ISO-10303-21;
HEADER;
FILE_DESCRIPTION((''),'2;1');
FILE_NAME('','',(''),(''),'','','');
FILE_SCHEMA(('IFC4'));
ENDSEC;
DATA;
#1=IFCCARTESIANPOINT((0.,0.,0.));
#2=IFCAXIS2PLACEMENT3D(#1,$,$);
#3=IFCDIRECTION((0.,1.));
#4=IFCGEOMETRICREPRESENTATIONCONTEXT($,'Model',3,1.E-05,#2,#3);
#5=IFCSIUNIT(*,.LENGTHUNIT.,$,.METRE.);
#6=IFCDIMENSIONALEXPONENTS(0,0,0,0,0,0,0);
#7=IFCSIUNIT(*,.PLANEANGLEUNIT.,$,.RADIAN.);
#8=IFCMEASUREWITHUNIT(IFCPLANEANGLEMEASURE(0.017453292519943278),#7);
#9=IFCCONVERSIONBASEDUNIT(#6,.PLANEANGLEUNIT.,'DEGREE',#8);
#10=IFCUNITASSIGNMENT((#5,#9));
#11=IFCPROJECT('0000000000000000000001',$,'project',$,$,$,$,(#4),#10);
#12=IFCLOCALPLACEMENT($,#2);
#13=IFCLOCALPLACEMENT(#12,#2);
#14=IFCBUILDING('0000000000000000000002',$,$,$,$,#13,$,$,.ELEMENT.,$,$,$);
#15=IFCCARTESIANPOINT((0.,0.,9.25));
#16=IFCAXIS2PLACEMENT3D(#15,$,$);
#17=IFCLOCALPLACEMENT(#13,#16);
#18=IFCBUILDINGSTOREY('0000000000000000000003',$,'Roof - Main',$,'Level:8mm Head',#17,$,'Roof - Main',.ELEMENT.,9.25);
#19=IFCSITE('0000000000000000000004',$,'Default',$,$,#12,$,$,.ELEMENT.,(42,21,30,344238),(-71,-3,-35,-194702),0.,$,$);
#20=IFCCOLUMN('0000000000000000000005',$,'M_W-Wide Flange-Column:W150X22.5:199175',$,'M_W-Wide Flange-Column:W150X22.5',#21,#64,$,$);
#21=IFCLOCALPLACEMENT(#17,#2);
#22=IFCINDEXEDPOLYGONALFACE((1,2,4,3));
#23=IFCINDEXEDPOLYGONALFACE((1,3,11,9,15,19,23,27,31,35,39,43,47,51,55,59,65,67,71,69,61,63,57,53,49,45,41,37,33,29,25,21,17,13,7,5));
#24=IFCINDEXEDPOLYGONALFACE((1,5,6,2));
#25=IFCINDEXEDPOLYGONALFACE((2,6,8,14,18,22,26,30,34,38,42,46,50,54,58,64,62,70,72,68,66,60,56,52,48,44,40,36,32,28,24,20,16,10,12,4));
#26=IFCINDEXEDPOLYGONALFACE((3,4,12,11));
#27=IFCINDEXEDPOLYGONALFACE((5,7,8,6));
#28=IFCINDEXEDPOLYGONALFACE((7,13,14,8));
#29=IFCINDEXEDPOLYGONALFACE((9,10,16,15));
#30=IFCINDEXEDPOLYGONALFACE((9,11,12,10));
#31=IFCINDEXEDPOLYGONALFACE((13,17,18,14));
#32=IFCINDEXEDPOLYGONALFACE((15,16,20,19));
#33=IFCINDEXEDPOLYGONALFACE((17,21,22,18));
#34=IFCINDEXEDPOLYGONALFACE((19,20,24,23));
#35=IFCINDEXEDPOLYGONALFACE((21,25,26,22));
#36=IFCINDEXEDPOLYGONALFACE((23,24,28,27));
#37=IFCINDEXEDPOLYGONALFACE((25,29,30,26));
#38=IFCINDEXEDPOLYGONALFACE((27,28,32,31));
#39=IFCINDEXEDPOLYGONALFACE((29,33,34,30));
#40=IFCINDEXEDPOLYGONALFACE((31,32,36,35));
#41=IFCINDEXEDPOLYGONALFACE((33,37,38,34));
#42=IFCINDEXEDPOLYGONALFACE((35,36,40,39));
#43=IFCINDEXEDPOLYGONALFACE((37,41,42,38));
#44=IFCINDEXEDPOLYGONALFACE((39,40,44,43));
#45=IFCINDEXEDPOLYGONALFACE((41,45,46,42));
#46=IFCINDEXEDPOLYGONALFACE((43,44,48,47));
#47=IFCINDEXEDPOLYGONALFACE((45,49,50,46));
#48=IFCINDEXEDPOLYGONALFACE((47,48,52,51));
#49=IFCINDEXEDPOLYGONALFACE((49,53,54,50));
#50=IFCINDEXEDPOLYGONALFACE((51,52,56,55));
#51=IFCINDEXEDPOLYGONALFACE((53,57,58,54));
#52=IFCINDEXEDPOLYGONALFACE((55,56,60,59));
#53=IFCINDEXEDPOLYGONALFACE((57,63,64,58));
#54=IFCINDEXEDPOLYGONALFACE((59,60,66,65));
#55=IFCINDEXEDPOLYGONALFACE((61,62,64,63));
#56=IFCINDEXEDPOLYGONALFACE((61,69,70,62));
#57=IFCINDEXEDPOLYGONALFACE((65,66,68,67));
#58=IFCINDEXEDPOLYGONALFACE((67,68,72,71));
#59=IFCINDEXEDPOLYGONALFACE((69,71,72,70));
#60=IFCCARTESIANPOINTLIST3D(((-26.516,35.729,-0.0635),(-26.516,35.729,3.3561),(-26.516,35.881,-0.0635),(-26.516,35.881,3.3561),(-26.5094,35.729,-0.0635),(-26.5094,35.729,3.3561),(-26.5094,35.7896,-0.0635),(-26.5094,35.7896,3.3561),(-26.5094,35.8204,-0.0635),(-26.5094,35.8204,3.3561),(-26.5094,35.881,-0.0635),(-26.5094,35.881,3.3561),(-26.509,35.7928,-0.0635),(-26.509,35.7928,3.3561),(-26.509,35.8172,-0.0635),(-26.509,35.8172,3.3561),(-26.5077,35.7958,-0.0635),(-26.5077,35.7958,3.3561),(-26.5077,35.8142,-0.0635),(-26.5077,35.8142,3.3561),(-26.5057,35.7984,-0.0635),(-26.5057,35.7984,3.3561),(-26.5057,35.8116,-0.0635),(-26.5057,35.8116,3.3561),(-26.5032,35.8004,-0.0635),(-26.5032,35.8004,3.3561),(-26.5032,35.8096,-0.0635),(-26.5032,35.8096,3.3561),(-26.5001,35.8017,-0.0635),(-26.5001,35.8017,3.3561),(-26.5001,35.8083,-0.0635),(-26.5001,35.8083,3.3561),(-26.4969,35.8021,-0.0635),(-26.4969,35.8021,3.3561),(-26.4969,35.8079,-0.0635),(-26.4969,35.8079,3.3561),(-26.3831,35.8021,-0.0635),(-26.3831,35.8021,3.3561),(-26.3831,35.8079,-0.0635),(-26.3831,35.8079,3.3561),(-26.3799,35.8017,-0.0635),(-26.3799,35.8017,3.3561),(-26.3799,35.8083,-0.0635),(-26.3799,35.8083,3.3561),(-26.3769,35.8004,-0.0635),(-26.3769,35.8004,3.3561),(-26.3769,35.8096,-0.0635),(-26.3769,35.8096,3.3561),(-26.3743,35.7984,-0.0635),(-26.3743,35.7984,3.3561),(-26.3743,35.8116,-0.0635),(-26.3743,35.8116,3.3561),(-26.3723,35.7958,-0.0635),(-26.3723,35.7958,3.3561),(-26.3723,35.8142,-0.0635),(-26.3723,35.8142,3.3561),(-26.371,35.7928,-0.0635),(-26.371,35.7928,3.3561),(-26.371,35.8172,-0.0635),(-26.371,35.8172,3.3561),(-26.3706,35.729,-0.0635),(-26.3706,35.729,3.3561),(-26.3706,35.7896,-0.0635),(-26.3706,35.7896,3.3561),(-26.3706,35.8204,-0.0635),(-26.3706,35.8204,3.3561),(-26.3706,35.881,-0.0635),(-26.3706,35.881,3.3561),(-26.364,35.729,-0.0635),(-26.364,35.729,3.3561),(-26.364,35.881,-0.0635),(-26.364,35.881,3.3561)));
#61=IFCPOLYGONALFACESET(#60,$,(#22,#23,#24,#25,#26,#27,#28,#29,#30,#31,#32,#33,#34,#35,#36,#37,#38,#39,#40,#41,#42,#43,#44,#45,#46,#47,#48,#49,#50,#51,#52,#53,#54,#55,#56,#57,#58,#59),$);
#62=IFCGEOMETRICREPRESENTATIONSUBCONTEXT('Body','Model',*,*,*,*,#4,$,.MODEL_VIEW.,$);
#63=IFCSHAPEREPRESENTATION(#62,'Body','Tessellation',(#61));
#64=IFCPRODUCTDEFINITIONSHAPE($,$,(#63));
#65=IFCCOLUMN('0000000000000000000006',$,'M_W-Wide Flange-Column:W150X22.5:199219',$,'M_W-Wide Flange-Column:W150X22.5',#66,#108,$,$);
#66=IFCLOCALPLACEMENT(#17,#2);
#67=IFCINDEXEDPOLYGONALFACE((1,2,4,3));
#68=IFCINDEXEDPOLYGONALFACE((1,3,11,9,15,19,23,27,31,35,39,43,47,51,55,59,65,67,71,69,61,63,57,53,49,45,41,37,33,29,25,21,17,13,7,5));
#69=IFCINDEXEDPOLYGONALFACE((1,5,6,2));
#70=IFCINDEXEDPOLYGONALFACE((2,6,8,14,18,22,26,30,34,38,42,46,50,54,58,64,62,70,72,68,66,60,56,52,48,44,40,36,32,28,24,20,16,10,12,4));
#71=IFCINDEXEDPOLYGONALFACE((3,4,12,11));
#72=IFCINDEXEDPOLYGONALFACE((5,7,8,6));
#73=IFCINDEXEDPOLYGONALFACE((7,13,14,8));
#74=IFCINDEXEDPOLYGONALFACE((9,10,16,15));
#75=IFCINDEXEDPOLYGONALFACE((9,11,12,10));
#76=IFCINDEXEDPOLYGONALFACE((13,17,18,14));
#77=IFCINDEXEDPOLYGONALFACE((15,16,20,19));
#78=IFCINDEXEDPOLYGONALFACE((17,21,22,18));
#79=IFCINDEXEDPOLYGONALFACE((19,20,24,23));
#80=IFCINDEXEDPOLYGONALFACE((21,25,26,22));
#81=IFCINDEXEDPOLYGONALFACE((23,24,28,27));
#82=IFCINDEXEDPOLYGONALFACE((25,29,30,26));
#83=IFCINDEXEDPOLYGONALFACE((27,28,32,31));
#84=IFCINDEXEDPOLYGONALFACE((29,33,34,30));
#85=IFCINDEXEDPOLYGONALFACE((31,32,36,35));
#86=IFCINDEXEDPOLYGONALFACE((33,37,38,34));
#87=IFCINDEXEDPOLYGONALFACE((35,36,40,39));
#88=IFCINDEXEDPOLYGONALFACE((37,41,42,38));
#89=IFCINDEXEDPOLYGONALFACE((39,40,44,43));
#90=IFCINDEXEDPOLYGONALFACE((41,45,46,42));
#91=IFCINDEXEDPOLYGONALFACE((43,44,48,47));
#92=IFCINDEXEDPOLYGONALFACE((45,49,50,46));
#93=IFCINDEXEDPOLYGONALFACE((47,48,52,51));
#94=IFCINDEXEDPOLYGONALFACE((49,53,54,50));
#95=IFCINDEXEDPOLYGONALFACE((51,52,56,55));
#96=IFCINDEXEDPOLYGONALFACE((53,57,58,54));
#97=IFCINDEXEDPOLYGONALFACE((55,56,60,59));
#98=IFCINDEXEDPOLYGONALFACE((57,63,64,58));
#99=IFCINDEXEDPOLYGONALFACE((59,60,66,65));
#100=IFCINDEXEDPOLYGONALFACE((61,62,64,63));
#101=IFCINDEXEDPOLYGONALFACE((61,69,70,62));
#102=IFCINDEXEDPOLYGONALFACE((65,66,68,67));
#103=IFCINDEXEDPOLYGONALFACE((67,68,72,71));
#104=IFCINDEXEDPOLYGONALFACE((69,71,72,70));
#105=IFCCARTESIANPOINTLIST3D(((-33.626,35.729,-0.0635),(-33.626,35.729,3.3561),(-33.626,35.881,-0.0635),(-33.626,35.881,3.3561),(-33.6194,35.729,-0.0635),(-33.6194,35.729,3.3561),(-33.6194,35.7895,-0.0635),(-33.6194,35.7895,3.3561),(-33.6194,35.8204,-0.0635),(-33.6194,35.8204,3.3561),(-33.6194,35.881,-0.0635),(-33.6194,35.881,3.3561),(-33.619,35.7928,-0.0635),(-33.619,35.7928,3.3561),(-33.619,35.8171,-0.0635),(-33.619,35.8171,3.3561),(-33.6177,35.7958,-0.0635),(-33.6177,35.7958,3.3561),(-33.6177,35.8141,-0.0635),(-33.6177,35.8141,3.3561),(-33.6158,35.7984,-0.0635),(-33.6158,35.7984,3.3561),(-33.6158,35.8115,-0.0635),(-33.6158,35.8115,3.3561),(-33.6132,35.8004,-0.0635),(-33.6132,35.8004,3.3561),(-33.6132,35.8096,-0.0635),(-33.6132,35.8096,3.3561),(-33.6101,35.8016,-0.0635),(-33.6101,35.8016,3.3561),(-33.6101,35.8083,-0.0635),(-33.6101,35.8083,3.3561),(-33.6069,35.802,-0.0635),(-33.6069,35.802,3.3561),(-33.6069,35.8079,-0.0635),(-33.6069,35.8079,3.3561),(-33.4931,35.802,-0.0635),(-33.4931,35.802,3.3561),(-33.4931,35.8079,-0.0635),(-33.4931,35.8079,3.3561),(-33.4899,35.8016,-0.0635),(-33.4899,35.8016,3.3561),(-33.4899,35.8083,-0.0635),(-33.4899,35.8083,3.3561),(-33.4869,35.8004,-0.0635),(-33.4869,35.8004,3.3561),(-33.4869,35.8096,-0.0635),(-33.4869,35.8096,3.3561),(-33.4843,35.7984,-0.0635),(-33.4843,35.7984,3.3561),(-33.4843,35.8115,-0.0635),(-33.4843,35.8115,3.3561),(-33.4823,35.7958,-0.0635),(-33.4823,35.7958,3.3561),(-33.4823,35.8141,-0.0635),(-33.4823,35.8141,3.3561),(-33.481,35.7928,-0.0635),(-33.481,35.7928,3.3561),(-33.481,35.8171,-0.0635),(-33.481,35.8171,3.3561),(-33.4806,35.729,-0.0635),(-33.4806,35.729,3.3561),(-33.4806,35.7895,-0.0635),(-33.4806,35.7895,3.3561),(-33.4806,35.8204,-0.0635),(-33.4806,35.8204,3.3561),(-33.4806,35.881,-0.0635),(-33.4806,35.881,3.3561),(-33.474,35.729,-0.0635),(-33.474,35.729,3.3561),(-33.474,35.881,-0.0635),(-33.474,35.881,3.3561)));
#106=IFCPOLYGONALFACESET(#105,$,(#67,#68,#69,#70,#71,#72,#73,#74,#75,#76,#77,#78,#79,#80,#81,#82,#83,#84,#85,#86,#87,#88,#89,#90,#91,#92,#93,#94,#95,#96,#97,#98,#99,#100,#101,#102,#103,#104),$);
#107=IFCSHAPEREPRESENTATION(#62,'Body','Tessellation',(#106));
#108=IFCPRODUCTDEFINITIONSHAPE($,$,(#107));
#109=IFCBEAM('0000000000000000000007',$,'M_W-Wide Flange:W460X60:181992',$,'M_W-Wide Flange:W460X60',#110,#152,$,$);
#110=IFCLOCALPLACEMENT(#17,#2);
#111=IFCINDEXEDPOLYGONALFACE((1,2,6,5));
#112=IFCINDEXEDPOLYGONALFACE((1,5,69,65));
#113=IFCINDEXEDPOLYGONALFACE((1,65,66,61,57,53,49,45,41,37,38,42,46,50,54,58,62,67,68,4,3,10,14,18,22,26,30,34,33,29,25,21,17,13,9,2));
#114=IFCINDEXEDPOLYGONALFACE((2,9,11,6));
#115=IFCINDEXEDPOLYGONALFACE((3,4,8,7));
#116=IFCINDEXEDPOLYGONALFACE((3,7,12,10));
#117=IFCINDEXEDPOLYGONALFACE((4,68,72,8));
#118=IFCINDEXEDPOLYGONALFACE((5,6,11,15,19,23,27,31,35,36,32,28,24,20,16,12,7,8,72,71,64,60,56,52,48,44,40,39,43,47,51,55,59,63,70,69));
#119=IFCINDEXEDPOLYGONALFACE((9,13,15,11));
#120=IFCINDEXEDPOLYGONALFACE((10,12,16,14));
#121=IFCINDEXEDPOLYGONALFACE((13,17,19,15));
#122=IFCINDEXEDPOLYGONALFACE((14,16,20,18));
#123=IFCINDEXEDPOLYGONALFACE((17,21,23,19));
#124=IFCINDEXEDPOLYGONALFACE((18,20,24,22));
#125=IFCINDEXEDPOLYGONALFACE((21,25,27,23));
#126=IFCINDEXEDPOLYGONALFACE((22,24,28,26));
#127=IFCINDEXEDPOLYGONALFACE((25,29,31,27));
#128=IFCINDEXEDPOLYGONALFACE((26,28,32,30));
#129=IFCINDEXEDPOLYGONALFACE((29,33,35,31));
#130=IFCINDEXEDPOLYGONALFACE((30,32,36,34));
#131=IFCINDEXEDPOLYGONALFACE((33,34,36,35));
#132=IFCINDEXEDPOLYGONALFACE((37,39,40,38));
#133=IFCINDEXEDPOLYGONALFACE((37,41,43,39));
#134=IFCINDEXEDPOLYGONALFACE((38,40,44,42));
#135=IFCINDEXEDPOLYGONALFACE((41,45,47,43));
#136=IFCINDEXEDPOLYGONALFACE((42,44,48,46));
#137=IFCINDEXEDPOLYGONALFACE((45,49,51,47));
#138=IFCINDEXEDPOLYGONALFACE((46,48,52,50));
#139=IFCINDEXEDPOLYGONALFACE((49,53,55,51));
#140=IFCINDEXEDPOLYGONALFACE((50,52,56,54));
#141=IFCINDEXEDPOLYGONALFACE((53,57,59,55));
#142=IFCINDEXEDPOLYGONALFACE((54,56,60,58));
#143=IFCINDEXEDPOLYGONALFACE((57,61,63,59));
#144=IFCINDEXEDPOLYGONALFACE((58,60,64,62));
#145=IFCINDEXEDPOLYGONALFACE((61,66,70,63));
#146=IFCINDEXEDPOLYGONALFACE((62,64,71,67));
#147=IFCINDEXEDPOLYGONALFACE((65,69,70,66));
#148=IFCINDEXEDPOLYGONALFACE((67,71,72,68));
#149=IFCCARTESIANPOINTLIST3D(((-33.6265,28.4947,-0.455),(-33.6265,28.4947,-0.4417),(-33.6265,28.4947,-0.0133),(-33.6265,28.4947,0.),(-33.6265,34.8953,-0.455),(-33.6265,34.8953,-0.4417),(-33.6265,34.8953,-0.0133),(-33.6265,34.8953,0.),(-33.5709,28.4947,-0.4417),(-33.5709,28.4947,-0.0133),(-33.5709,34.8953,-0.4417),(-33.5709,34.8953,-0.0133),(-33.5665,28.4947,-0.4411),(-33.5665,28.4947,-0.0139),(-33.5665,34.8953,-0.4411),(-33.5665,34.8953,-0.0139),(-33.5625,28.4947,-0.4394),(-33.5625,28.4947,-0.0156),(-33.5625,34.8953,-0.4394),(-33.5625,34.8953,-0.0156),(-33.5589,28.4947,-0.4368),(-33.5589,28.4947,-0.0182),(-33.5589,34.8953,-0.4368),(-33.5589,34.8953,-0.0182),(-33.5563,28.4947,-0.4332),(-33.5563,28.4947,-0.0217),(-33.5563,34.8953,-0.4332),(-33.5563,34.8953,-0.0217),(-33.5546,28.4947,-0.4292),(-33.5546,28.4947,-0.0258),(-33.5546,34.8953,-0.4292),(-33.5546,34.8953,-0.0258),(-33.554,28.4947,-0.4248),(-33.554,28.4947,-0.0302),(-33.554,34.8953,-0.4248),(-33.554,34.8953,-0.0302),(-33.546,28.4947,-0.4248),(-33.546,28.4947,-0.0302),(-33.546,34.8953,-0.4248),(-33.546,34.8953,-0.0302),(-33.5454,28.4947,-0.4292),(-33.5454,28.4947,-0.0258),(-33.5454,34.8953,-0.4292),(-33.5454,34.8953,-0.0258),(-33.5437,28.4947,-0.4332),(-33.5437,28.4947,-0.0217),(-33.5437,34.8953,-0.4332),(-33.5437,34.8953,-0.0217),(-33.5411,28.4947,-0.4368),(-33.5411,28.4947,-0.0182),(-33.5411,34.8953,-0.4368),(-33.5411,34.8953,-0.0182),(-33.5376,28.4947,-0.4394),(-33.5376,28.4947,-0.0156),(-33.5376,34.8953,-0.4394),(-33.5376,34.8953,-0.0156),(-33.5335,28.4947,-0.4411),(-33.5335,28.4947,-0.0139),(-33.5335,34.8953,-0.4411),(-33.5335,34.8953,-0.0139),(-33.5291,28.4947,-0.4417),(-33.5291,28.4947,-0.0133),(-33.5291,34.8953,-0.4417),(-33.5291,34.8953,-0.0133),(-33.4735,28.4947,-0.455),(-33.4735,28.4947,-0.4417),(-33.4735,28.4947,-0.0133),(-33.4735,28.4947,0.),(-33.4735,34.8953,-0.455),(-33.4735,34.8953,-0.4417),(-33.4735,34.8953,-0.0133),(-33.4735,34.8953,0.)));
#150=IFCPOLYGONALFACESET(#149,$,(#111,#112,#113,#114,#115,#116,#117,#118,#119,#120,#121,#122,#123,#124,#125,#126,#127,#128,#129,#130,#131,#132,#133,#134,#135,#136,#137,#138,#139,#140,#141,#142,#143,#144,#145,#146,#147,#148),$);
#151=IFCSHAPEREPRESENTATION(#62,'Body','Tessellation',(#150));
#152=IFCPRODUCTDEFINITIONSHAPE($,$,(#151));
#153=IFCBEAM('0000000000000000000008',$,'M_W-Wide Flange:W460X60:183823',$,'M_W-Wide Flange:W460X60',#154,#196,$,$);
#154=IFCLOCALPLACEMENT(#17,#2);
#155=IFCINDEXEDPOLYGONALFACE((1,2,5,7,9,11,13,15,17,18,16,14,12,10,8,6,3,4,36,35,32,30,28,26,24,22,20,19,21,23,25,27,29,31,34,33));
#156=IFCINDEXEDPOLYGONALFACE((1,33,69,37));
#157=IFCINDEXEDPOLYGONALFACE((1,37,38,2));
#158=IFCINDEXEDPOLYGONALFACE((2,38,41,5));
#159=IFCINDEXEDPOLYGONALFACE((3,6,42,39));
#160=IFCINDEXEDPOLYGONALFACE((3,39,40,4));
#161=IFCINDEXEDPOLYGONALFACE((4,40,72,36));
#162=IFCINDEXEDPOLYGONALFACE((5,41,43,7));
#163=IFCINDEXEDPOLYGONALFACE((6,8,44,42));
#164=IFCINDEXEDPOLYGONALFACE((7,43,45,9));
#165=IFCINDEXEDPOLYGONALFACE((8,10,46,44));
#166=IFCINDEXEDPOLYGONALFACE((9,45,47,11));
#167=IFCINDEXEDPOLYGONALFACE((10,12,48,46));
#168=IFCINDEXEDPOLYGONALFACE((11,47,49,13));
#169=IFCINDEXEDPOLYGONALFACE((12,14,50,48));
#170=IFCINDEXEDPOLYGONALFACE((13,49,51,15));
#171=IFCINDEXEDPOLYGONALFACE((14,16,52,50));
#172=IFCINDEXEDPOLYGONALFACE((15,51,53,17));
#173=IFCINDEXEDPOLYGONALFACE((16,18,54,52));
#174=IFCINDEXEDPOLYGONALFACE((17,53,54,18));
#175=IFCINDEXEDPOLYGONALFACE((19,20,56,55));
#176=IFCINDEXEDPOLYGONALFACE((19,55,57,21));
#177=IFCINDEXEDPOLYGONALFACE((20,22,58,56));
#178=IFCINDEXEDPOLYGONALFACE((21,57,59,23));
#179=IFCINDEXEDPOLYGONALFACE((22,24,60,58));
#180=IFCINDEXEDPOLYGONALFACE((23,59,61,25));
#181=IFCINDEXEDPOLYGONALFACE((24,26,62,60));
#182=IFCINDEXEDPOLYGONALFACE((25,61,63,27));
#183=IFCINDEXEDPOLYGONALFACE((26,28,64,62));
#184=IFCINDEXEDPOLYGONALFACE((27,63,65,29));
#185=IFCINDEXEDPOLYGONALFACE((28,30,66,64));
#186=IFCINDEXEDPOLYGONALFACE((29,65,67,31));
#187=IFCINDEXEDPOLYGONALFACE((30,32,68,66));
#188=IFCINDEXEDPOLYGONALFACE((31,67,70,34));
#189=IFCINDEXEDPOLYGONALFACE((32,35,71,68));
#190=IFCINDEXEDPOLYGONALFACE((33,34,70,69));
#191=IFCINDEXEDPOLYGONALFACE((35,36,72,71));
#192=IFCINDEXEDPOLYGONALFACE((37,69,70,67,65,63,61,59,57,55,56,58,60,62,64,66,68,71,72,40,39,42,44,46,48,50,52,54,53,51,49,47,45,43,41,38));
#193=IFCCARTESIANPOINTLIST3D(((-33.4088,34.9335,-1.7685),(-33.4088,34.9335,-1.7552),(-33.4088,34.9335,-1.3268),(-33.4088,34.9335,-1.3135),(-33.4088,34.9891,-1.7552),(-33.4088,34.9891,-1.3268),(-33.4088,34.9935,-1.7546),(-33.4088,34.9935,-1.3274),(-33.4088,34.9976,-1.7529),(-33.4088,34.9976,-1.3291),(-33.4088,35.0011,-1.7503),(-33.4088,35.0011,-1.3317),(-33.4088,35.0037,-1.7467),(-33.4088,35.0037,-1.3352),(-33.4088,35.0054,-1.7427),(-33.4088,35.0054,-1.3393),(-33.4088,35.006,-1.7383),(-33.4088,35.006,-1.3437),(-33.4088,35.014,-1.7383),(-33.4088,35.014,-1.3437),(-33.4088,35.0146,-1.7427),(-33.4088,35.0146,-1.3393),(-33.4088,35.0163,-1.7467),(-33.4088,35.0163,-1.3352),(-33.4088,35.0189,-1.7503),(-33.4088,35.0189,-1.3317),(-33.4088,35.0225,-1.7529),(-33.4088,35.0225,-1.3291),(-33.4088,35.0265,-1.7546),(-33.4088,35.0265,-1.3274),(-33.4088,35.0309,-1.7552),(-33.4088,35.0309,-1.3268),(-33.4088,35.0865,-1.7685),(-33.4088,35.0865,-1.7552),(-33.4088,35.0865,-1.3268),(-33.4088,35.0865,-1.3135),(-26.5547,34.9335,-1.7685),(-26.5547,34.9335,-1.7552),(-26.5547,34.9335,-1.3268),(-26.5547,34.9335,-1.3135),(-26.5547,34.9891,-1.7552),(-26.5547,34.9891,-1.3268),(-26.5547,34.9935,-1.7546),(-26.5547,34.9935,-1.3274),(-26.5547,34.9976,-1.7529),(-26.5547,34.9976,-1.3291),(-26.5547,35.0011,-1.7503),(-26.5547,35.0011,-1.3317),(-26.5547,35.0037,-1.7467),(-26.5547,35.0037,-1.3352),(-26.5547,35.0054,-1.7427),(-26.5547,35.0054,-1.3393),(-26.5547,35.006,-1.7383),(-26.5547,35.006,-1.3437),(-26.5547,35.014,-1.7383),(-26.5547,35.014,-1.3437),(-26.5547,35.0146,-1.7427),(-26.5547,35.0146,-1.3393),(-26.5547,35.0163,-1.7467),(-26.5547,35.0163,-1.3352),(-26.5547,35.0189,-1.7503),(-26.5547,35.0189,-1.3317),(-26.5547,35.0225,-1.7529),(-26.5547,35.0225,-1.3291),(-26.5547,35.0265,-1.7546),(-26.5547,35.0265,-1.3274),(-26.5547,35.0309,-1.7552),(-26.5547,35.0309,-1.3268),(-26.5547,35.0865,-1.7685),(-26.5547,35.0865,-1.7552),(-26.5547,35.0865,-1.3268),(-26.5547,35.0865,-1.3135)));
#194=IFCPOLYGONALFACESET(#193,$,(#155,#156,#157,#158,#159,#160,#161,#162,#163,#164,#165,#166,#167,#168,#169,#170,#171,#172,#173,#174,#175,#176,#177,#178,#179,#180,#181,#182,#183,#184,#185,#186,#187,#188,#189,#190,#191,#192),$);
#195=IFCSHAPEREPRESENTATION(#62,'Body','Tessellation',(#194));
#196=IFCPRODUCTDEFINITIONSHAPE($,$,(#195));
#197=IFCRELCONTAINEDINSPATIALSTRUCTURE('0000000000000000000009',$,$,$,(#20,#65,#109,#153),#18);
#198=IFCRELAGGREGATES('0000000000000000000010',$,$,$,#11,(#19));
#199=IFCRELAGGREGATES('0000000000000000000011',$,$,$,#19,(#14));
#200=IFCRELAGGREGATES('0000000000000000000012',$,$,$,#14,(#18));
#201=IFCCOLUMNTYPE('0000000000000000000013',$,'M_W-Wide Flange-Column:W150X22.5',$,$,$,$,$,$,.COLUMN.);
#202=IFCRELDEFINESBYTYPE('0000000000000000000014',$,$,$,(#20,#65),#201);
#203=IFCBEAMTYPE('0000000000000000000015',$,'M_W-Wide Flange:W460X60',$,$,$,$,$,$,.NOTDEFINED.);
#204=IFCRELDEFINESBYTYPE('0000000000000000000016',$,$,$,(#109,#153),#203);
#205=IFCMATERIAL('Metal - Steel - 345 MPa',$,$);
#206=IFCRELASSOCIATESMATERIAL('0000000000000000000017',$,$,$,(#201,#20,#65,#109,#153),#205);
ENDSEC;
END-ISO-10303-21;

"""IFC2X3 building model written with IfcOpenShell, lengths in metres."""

from ifc_helpers import new_model, entity, si_unit, converted_unit, direction, frame, frame_2d, origin, place, context, subcontext, project, spatial, i_section, extrude, source, transform, mapped, material, type_object, type_shapes, element, save


model = new_model("IFC2X3")

# Units and contexts
model_context = context("Model", 3, precision=1e-05, world=origin(), true_north=direction((0.0, 1.0)))
body_context = subcontext(model_context, "Body", "Model", "MODEL_VIEW")
ifc_project = project(units=[si_unit("LENGTHUNIT", "METRE"), converted_unit("PLANEANGLEUNIT", "DEGREE", entity("IfcPlaneAngleMeasure", 0.017453292519943278), si_unit("PLANEANGLEUNIT", "RADIAN"), dimensions=[0, 0, 0, 0, 0, 0, 0])], contexts=[model_context])

# Site, building, storey
site_placement = place(None, origin())
site = spatial("IfcSite", under=ifc_project, at=site_placement, Name="Default", CompositionType="ELEMENT", RefLatitude=(42, 21, 30, 344238), RefLongitude=(-71, -3, -35, -194702), RefElevation=0.0)
building_placement = place(site_placement, origin())
building = spatial("IfcBuilding", under=site, at=building_placement, CompositionType="ELEMENT")
storey_placement = place(building_placement, frame((0.0, 0.0, 9.25)))
storey = spatial("IfcBuildingStorey", under=building, at=storey_placement, Name="Roof - Main", ObjectType="Level:8mm Head", LongName="Roof - Main", CompositionType="ELEMENT", Elevation=9.25)

# Columns
ifc_material_1 = material(Name="Metal - Steel - 345 MPa")
column_type = type_object("IfcColumnType", Name="M_W-Wide Flange-Column:W150X22.5", PredefinedType="COLUMN", material=ifc_material_1)
shared_shape_1 = source(origin(), body_context, "Body", "SweptSolid", [
    extrude(i_section(OverallWidth=0.152, OverallDepth=0.152, WebThickness=0.0058, FlangeThickness=0.0066, FilletRadius=0.0125, at=frame_2d((0.0, 0.0), x_axis=(1.0, 0.0))), frame((0.0, 0.0, 9.1865), z_axis=(0.0, 0.0, 1.0), x_axis=(-1.0, 0.0, 0.0)), (0.0, 0.0, 1.0), 3.4196),
])
type_shapes(column_type, [shared_shape_1])
for number, where, z_axis, x_axis, name in (
    (1, (-26.44, 35.805, -9.25), (0.0, 0.0, 1.0), (0.0, 1.0, 0.0), "M_W-Wide Flange-Column:W150X22.5:199175"),
    (2, (-33.55, 35.805, -9.25), (0.0, 0.0, 1.0), (0.0, 1.0, 0.0), "M_W-Wide Flange-Column:W150X22.5:199219"),
):
    element("IfcColumn", number, at=place(storey_placement, frame(where, z_axis=z_axis, x_axis=x_axis)), inside=storey, type_object=column_type, material=ifc_material_1, Name=name, ObjectType="M_W-Wide Flange-Column:W150X22.5", context=body_context, shape_type="MappedRepresentation", body=[
        mapped(shared_shape_1, transform((0.0, 0.0, 0.0), scale=1.0)),
    ])

# Beams
beam_type_1 = type_object("IfcBeamType", Name="M_W-Wide Flange:W460X60", PredefinedType="NOTDEFINED")
beam_1_placement = place(storey_placement, frame((-33.55, 35.01, 0.0), z_axis=(0.0, 0.0, 1.0), x_axis=(0.0, -1.0, 0.0)))
element("IfcBeam", 3, at=beam_1_placement, inside=storey, type_object=beam_type_1, material=ifc_material_1, Name="M_W-Wide Flange:W460X60:181992", ObjectType="M_W-Wide Flange:W460X60", context=body_context, shape_type="SweptSolid", body=[
    extrude(i_section(OverallWidth=0.153, OverallDepth=0.455, WebThickness=0.008, FlangeThickness=0.0133, FilletRadius=0.0169, at=frame_2d((0.0, 0.0), x_axis=(0.0, 1.0))), frame((0.1147, 0.0, -0.2275), z_axis=(1.0, 0.0, 0.0), x_axis=(0.0, 0.0, -1.0)), (0.0, 0.0, 1.0), 6.4006),
])
beam_2_placement = place(storey_placement, frame((-26.44, 35.01, -1.3135), z_axis=(0.0, 0.0, 1.0), x_axis=(-1.0, 0.0, 0.0)))
element("IfcBeam", 4, at=beam_2_placement, inside=storey, type_object=beam_type_1, material=ifc_material_1, Name="M_W-Wide Flange:W460X60:183823", ObjectType="M_W-Wide Flange:W460X60", context=body_context, shape_type="SweptSolid", body=[
    extrude(i_section(OverallWidth=0.153, OverallDepth=0.455, WebThickness=0.008, FlangeThickness=0.0133, FilletRadius=0.0169, at=frame_2d((0.0, 0.0), x_axis=(0.0, 1.0))), frame((0.1147, 0.0, -0.2275), z_axis=(1.0, 0.0, 0.0), x_axis=(0.0, 0.0, -1.0)), (0.0, 0.0, 1.0), 6.8541),
])

save(model, "model.ifc")
